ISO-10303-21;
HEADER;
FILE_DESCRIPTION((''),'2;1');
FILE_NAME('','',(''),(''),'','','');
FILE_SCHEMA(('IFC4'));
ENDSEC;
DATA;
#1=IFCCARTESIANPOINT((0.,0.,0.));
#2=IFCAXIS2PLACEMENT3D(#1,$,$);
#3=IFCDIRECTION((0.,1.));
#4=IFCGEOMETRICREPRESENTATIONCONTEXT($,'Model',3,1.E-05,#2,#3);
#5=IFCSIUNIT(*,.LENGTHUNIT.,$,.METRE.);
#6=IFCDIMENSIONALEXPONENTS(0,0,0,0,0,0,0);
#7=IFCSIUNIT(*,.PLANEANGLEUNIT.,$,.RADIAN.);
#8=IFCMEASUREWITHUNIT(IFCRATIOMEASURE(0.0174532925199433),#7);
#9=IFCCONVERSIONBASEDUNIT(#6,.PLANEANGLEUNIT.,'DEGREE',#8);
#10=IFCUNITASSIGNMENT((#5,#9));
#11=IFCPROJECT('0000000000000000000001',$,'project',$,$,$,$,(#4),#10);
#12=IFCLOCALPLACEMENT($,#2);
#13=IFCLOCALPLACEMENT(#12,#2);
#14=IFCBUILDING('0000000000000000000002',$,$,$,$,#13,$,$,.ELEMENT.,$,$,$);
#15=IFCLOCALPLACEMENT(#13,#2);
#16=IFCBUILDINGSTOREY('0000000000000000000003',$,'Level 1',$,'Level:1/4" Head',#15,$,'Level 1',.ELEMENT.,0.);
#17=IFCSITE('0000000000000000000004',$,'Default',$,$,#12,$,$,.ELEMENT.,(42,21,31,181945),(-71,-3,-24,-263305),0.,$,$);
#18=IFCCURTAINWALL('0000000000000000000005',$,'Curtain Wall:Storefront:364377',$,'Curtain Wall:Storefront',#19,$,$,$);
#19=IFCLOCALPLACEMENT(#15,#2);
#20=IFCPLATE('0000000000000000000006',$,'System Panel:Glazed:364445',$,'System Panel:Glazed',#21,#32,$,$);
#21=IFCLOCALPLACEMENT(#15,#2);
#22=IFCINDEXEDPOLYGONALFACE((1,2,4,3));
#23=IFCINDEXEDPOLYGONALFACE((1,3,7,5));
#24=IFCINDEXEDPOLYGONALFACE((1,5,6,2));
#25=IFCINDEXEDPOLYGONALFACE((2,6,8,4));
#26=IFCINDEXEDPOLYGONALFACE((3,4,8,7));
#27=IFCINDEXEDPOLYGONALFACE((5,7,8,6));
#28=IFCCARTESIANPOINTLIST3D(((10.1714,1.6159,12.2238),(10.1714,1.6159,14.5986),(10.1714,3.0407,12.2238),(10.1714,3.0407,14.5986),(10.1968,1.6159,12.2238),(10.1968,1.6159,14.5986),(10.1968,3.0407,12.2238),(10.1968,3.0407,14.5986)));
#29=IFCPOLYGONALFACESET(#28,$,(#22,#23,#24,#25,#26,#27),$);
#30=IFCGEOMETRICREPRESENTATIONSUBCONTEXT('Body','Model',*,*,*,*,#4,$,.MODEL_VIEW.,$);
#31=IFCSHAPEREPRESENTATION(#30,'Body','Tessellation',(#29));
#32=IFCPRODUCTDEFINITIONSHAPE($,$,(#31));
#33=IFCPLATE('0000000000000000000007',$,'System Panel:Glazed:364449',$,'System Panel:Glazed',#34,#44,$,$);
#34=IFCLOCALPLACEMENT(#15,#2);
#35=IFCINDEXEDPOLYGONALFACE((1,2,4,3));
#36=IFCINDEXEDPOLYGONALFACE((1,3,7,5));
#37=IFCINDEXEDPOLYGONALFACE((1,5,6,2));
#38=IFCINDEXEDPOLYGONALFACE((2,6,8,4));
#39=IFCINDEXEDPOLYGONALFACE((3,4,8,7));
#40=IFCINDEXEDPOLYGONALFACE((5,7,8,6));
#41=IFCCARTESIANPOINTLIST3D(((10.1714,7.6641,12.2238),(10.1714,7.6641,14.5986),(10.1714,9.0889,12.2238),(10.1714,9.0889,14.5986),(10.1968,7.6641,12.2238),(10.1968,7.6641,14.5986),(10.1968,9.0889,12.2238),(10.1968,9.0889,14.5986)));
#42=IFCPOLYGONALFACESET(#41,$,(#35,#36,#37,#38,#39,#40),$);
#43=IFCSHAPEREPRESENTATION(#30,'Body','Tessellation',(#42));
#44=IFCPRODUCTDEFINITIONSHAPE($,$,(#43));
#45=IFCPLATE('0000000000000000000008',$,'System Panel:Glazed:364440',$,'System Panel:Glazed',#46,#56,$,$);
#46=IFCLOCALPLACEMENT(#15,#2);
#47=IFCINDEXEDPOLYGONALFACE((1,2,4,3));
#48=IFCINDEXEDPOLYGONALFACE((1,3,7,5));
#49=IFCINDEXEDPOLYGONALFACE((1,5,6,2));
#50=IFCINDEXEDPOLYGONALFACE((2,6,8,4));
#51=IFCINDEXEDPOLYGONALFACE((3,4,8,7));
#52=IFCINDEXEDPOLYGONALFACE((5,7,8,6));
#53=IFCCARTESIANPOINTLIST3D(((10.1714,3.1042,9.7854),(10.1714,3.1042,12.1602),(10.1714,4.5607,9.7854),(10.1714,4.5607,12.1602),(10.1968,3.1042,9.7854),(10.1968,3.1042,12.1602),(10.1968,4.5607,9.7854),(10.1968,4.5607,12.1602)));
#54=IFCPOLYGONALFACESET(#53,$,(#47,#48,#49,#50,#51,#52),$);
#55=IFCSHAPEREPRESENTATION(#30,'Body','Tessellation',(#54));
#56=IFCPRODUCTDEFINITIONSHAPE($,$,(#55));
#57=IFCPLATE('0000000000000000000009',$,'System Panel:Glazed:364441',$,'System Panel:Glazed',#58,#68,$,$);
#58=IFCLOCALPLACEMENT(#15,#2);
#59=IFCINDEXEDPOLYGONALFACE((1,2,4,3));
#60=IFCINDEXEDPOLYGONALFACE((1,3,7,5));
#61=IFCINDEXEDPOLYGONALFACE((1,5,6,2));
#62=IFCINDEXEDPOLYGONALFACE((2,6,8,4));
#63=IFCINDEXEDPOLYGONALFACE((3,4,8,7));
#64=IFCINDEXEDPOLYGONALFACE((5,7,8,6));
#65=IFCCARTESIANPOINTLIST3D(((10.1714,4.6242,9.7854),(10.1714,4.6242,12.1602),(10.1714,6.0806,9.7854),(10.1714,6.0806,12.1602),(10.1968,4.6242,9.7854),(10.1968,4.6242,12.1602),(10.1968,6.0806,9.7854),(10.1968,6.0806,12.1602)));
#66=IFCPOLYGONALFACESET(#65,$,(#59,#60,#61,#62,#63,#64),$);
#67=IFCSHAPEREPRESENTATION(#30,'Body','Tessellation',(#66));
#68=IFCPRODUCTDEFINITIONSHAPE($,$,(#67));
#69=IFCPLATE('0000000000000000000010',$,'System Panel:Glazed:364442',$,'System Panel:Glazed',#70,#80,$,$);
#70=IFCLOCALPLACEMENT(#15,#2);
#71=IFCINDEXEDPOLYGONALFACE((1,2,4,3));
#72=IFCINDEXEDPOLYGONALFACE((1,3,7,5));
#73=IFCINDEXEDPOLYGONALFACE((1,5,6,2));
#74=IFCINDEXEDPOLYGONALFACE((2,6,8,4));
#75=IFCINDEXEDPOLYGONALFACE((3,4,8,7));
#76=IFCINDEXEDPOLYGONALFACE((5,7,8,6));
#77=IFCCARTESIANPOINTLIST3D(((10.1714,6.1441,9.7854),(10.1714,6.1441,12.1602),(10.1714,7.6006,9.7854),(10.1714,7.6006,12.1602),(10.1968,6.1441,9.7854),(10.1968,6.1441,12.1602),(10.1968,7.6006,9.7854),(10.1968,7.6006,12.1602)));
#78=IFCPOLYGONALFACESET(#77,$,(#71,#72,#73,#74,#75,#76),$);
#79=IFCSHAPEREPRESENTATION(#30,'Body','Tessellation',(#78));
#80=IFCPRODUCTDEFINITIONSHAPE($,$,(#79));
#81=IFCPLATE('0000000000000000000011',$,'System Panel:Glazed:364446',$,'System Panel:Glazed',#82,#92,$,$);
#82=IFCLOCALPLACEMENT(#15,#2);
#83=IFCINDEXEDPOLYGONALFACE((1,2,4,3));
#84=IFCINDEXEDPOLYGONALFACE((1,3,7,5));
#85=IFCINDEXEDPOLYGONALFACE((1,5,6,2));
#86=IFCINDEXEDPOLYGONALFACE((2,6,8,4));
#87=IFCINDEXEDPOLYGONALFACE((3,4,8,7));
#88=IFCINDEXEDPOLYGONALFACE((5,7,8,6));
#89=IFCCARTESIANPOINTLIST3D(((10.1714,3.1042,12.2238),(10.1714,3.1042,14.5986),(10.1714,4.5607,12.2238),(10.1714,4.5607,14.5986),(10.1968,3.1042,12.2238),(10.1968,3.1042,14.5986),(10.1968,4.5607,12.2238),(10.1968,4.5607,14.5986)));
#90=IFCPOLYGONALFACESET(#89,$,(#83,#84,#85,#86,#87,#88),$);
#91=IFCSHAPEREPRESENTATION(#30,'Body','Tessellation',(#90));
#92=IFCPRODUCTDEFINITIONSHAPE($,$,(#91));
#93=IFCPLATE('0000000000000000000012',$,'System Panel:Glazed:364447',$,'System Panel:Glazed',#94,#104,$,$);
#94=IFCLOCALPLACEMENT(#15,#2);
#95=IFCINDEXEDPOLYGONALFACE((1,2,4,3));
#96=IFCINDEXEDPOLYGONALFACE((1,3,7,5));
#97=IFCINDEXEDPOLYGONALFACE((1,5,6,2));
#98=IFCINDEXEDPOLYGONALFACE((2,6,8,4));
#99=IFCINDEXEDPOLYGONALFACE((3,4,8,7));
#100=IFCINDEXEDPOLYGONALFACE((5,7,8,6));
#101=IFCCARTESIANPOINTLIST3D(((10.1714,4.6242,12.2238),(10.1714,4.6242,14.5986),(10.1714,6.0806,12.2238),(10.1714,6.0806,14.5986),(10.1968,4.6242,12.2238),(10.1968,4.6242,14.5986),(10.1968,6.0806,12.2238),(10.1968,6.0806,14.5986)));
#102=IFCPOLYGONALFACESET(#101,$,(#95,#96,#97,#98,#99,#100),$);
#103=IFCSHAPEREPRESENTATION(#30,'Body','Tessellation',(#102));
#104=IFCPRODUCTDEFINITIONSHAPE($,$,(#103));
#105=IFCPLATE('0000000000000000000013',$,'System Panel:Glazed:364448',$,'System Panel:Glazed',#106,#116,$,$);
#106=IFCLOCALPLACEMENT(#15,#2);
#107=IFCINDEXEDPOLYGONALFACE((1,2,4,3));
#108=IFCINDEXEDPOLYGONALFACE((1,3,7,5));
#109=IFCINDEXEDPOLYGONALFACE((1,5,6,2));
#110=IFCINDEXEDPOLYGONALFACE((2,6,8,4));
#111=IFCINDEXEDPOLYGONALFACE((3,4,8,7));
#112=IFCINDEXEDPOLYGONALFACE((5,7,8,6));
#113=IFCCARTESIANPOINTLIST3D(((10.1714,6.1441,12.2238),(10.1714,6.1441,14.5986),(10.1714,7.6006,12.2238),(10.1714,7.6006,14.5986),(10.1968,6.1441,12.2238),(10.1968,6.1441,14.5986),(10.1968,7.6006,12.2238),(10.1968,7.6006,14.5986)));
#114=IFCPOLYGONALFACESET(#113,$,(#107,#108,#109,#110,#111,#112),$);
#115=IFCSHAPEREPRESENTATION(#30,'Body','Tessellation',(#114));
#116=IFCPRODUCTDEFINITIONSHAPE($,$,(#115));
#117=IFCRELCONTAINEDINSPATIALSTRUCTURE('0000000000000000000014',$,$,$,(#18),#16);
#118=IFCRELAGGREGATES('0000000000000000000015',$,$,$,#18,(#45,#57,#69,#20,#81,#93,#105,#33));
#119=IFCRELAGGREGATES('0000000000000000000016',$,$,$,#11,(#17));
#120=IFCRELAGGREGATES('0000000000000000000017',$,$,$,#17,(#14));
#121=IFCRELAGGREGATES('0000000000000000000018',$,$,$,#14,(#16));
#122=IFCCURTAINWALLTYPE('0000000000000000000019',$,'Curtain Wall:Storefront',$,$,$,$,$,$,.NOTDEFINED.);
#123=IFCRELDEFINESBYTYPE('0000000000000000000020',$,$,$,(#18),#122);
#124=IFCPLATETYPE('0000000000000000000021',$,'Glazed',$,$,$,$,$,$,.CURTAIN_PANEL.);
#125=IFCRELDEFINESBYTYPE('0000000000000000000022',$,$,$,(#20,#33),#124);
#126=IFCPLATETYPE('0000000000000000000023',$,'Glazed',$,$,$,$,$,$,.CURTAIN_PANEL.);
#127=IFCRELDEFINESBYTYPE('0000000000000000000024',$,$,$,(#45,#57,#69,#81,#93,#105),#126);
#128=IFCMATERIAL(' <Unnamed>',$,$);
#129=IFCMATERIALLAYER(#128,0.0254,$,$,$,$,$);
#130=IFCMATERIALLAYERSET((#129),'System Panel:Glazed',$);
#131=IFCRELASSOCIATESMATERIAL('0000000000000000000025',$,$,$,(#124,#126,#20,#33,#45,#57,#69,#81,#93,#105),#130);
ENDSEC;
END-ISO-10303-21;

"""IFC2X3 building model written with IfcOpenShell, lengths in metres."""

from ifc_helpers import new_model, entity, si_unit, converted_unit, direction, frame, frame_2d, origin, origin_2d_with_axis, place, context, subcontext, project, spatial, rectangle, extrude, source, transform, mapped, material, layer, layer_set, layer_usage, type_object, type_shapes, element, aggregate, save


model = new_model("IFC2X3")

# Units and contexts
model_context = context("Model", 3, precision=1e-05, world=origin(), true_north=direction((0.0, 1.0)))
body_context = subcontext(model_context, "Body", "Model", "MODEL_VIEW")
ifc_project = project(units=[si_unit("LENGTHUNIT", "METRE"), converted_unit("PLANEANGLEUNIT", "DEGREE", entity("IfcRatioMeasure", 0.0174532925199433), si_unit("PLANEANGLEUNIT", "RADIAN"), dimensions=[0, 0, 0, 0, 0, 0, 0])], contexts=[model_context])

# Site, building, storey
site_placement = place(None, origin())
site = spatial("IfcSite", under=ifc_project, at=site_placement, Name="Default", CompositionType="ELEMENT", RefLatitude=(42, 21, 31, 181945), RefLongitude=(-71, -3, -24, -263305), RefElevation=0.0)
building_placement = place(site_placement, origin())
building = spatial("IfcBuilding", under=site, at=building_placement, CompositionType="ELEMENT")
storey_placement = place(building_placement, origin())
storey = spatial("IfcBuildingStorey", under=building, at=storey_placement, Name="Level 1", ObjectType="Level:1/4\" Head", LongName="Level 1", CompositionType="ELEMENT", Elevation=0.0)

# Shared definitions
curtain_wall_type = type_object("IfcCurtainWallType", Name="Curtain Wall:Storefront", PredefinedType="NOTDEFINED")

# Curtain wall, plates
curtain_wall_1_placement = place(storey_placement, origin())
curtain_wall_1 = element("IfcCurtainWall", 1, at=curtain_wall_1_placement, inside=storey, type_object=curtain_wall_type, Name="Curtain Wall:Storefront:364377", ObjectType="Curtain Wall:Storefront")
ifc_material_1 = material(Name=" <Unnamed>")
ifc_layer = layer(ifc_material_1, 0.0254)
ifc_layer_set = layer_set([ifc_layer], Name="System Panel:Glazed")
plate_type_1 = type_object("IfcPlateType", Name="Glazed", PredefinedType="CURTAIN_PANEL", material=ifc_layer_set)
shared_shape_1 = source(origin(), body_context, "Body", "SweptSolid", [
    extrude(rectangle(XDim=0.0254, YDim=1.4248, at=frame_2d((0.0, 0.0), x_axis=(1.0, 0.0))), frame((0.7124, 0.0127, 0.0), z_axis=(0.0, 0.0, 1.0), x_axis=(0.0, 1.0, 0.0)), (0.0, 0.0, 1.0), 2.3749),
])
type_shapes(plate_type_1, [shared_shape_1])
ifc_layer_usage_1 = layer_usage(ifc_layer_set, "AXIS3", "POSITIVE", 0.1042)
plate_1_placement = place(curtain_wall_1_placement, frame((10.1968, 1.6159, 12.2238), z_axis=(0.0, 0.0, 1.0), x_axis=(0.0, 1.0, 0.0)))
plate_1 = element("IfcPlate", 2, at=plate_1_placement, type_object=plate_type_1, material=ifc_layer_usage_1, Name="System Panel:Glazed:364445", ObjectType="System Panel:Glazed", context=body_context, shape_type="MappedRepresentation", body=[
    mapped(shared_shape_1, transform((0.0, 0.0, 0.0), scale=1.0)),
])
ifc_layer_usage_2 = layer_usage(ifc_layer_set, "AXIS3", "POSITIVE", 0.1042)
plate_2_placement = place(curtain_wall_1_placement, frame((10.1968, 7.6641, 12.2238), z_axis=(0.0, 0.0, 1.0), x_axis=(0.0, 1.0, 0.0)))
plate_2 = element("IfcPlate", 3, at=plate_2_placement, type_object=plate_type_1, material=ifc_layer_usage_2, Name="System Panel:Glazed:364449", ObjectType="System Panel:Glazed", context=body_context, shape_type="MappedRepresentation", body=[
    mapped(shared_shape_1, transform((0.0, 0.0, 0.0), scale=1.0)),
])
ifc_layer_usage_3 = layer_usage(ifc_layer_set, "AXIS3", "POSITIVE", 0.1042)
plate_type_2 = type_object("IfcPlateType", Name="Glazed", PredefinedType="CURTAIN_PANEL", material=ifc_layer_set)
shared_shape_2 = source(origin(), body_context, "Body", "SweptSolid", [
    extrude(rectangle(XDim=0.0254, YDim=1.4565, at=origin_2d_with_axis()), frame((0.7282, 0.0127, 0.0), z_axis=(0.0, 0.0, 1.0), x_axis=(0.0, 1.0, 0.0)), (0.0, 0.0, 1.0), 2.3749),
])
type_shapes(plate_type_2, [shared_shape_2])
plate_3_placement = place(curtain_wall_1_placement, frame((10.1968, 3.1042, 9.7853), z_axis=(0.0, 0.0, 1.0), x_axis=(0.0, 1.0, 0.0)))
plate_3 = element("IfcPlate", 4, at=plate_3_placement, type_object=plate_type_2, material=ifc_layer_usage_3, Name="System Panel:Glazed:364440", ObjectType="System Panel:Glazed", context=body_context, shape_type="MappedRepresentation", body=[
    mapped(shared_shape_2, transform((0.0, 0.0, 0.0), scale=1.0)),
])
ifc_layer_usage_4 = layer_usage(ifc_layer_set, "AXIS3", "POSITIVE", 0.1042)
plate_4_placement = place(curtain_wall_1_placement, frame((10.1968, 4.6242, 9.7853), z_axis=(0.0, 0.0, 1.0), x_axis=(0.0, 1.0, 0.0)))
plate_4 = element("IfcPlate", 5, at=plate_4_placement, type_object=plate_type_2, material=ifc_layer_usage_4, Name="System Panel:Glazed:364441", ObjectType="System Panel:Glazed", context=body_context, shape_type="MappedRepresentation", body=[
    mapped(shared_shape_2, transform((0.0, 0.0, 0.0), scale=1.0)),
])
ifc_layer_usage_5 = layer_usage(ifc_layer_set, "AXIS3", "POSITIVE", 0.1042)
plate_5_placement = place(curtain_wall_1_placement, frame((10.1968, 6.1441, 9.7853), z_axis=(0.0, 0.0, 1.0), x_axis=(0.0, 1.0, 0.0)))
plate_5 = element("IfcPlate", 6, at=plate_5_placement, type_object=plate_type_2, material=ifc_layer_usage_5, Name="System Panel:Glazed:364442", ObjectType="System Panel:Glazed", context=body_context, shape_type="MappedRepresentation", body=[
    mapped(shared_shape_2, transform((0.0, 0.0, 0.0), scale=1.0)),
])
ifc_layer_usage_6 = layer_usage(ifc_layer_set, "AXIS3", "POSITIVE", 0.1042)
plate_6_placement = place(curtain_wall_1_placement, frame((10.1968, 3.1042, 12.2238), z_axis=(0.0, 0.0, 1.0), x_axis=(0.0, 1.0, 0.0)))
plate_6 = element("IfcPlate", 7, at=plate_6_placement, type_object=plate_type_2, material=ifc_layer_usage_6, Name="System Panel:Glazed:364446", ObjectType="System Panel:Glazed", context=body_context, shape_type="MappedRepresentation", body=[
    mapped(shared_shape_2, transform((0.0, 0.0, 0.0), scale=1.0)),
])
ifc_layer_usage_7 = layer_usage(ifc_layer_set, "AXIS3", "POSITIVE", 0.1042)
plate_7_placement = place(curtain_wall_1_placement, frame((10.1968, 4.6242, 12.2238), z_axis=(0.0, 0.0, 1.0), x_axis=(0.0, 1.0, 0.0)))
plate_7 = element("IfcPlate", 8, at=plate_7_placement, type_object=plate_type_2, material=ifc_layer_usage_7, Name="System Panel:Glazed:364447", ObjectType="System Panel:Glazed", context=body_context, shape_type="MappedRepresentation", body=[
    mapped(shared_shape_2, transform((0.0, 0.0, 0.0), scale=1.0)),
])
ifc_layer_usage_8 = layer_usage(ifc_layer_set, "AXIS3", "POSITIVE", 0.1042)
plate_8_placement = place(curtain_wall_1_placement, frame((10.1968, 6.1441, 12.2238), z_axis=(0.0, 0.0, 1.0), x_axis=(0.0, 1.0, 0.0)))
plate_8 = element("IfcPlate", 9, at=plate_8_placement, type_object=plate_type_2, material=ifc_layer_usage_8, Name="System Panel:Glazed:364448", ObjectType="System Panel:Glazed", context=body_context, shape_type="MappedRepresentation", body=[
    mapped(shared_shape_2, transform((0.0, 0.0, 0.0), scale=1.0)),
])
aggregate(curtain_wall_1, [plate_3, plate_4, plate_5, plate_1, plate_6, plate_7, plate_8, plate_2])

save(model, "model.ifc")
